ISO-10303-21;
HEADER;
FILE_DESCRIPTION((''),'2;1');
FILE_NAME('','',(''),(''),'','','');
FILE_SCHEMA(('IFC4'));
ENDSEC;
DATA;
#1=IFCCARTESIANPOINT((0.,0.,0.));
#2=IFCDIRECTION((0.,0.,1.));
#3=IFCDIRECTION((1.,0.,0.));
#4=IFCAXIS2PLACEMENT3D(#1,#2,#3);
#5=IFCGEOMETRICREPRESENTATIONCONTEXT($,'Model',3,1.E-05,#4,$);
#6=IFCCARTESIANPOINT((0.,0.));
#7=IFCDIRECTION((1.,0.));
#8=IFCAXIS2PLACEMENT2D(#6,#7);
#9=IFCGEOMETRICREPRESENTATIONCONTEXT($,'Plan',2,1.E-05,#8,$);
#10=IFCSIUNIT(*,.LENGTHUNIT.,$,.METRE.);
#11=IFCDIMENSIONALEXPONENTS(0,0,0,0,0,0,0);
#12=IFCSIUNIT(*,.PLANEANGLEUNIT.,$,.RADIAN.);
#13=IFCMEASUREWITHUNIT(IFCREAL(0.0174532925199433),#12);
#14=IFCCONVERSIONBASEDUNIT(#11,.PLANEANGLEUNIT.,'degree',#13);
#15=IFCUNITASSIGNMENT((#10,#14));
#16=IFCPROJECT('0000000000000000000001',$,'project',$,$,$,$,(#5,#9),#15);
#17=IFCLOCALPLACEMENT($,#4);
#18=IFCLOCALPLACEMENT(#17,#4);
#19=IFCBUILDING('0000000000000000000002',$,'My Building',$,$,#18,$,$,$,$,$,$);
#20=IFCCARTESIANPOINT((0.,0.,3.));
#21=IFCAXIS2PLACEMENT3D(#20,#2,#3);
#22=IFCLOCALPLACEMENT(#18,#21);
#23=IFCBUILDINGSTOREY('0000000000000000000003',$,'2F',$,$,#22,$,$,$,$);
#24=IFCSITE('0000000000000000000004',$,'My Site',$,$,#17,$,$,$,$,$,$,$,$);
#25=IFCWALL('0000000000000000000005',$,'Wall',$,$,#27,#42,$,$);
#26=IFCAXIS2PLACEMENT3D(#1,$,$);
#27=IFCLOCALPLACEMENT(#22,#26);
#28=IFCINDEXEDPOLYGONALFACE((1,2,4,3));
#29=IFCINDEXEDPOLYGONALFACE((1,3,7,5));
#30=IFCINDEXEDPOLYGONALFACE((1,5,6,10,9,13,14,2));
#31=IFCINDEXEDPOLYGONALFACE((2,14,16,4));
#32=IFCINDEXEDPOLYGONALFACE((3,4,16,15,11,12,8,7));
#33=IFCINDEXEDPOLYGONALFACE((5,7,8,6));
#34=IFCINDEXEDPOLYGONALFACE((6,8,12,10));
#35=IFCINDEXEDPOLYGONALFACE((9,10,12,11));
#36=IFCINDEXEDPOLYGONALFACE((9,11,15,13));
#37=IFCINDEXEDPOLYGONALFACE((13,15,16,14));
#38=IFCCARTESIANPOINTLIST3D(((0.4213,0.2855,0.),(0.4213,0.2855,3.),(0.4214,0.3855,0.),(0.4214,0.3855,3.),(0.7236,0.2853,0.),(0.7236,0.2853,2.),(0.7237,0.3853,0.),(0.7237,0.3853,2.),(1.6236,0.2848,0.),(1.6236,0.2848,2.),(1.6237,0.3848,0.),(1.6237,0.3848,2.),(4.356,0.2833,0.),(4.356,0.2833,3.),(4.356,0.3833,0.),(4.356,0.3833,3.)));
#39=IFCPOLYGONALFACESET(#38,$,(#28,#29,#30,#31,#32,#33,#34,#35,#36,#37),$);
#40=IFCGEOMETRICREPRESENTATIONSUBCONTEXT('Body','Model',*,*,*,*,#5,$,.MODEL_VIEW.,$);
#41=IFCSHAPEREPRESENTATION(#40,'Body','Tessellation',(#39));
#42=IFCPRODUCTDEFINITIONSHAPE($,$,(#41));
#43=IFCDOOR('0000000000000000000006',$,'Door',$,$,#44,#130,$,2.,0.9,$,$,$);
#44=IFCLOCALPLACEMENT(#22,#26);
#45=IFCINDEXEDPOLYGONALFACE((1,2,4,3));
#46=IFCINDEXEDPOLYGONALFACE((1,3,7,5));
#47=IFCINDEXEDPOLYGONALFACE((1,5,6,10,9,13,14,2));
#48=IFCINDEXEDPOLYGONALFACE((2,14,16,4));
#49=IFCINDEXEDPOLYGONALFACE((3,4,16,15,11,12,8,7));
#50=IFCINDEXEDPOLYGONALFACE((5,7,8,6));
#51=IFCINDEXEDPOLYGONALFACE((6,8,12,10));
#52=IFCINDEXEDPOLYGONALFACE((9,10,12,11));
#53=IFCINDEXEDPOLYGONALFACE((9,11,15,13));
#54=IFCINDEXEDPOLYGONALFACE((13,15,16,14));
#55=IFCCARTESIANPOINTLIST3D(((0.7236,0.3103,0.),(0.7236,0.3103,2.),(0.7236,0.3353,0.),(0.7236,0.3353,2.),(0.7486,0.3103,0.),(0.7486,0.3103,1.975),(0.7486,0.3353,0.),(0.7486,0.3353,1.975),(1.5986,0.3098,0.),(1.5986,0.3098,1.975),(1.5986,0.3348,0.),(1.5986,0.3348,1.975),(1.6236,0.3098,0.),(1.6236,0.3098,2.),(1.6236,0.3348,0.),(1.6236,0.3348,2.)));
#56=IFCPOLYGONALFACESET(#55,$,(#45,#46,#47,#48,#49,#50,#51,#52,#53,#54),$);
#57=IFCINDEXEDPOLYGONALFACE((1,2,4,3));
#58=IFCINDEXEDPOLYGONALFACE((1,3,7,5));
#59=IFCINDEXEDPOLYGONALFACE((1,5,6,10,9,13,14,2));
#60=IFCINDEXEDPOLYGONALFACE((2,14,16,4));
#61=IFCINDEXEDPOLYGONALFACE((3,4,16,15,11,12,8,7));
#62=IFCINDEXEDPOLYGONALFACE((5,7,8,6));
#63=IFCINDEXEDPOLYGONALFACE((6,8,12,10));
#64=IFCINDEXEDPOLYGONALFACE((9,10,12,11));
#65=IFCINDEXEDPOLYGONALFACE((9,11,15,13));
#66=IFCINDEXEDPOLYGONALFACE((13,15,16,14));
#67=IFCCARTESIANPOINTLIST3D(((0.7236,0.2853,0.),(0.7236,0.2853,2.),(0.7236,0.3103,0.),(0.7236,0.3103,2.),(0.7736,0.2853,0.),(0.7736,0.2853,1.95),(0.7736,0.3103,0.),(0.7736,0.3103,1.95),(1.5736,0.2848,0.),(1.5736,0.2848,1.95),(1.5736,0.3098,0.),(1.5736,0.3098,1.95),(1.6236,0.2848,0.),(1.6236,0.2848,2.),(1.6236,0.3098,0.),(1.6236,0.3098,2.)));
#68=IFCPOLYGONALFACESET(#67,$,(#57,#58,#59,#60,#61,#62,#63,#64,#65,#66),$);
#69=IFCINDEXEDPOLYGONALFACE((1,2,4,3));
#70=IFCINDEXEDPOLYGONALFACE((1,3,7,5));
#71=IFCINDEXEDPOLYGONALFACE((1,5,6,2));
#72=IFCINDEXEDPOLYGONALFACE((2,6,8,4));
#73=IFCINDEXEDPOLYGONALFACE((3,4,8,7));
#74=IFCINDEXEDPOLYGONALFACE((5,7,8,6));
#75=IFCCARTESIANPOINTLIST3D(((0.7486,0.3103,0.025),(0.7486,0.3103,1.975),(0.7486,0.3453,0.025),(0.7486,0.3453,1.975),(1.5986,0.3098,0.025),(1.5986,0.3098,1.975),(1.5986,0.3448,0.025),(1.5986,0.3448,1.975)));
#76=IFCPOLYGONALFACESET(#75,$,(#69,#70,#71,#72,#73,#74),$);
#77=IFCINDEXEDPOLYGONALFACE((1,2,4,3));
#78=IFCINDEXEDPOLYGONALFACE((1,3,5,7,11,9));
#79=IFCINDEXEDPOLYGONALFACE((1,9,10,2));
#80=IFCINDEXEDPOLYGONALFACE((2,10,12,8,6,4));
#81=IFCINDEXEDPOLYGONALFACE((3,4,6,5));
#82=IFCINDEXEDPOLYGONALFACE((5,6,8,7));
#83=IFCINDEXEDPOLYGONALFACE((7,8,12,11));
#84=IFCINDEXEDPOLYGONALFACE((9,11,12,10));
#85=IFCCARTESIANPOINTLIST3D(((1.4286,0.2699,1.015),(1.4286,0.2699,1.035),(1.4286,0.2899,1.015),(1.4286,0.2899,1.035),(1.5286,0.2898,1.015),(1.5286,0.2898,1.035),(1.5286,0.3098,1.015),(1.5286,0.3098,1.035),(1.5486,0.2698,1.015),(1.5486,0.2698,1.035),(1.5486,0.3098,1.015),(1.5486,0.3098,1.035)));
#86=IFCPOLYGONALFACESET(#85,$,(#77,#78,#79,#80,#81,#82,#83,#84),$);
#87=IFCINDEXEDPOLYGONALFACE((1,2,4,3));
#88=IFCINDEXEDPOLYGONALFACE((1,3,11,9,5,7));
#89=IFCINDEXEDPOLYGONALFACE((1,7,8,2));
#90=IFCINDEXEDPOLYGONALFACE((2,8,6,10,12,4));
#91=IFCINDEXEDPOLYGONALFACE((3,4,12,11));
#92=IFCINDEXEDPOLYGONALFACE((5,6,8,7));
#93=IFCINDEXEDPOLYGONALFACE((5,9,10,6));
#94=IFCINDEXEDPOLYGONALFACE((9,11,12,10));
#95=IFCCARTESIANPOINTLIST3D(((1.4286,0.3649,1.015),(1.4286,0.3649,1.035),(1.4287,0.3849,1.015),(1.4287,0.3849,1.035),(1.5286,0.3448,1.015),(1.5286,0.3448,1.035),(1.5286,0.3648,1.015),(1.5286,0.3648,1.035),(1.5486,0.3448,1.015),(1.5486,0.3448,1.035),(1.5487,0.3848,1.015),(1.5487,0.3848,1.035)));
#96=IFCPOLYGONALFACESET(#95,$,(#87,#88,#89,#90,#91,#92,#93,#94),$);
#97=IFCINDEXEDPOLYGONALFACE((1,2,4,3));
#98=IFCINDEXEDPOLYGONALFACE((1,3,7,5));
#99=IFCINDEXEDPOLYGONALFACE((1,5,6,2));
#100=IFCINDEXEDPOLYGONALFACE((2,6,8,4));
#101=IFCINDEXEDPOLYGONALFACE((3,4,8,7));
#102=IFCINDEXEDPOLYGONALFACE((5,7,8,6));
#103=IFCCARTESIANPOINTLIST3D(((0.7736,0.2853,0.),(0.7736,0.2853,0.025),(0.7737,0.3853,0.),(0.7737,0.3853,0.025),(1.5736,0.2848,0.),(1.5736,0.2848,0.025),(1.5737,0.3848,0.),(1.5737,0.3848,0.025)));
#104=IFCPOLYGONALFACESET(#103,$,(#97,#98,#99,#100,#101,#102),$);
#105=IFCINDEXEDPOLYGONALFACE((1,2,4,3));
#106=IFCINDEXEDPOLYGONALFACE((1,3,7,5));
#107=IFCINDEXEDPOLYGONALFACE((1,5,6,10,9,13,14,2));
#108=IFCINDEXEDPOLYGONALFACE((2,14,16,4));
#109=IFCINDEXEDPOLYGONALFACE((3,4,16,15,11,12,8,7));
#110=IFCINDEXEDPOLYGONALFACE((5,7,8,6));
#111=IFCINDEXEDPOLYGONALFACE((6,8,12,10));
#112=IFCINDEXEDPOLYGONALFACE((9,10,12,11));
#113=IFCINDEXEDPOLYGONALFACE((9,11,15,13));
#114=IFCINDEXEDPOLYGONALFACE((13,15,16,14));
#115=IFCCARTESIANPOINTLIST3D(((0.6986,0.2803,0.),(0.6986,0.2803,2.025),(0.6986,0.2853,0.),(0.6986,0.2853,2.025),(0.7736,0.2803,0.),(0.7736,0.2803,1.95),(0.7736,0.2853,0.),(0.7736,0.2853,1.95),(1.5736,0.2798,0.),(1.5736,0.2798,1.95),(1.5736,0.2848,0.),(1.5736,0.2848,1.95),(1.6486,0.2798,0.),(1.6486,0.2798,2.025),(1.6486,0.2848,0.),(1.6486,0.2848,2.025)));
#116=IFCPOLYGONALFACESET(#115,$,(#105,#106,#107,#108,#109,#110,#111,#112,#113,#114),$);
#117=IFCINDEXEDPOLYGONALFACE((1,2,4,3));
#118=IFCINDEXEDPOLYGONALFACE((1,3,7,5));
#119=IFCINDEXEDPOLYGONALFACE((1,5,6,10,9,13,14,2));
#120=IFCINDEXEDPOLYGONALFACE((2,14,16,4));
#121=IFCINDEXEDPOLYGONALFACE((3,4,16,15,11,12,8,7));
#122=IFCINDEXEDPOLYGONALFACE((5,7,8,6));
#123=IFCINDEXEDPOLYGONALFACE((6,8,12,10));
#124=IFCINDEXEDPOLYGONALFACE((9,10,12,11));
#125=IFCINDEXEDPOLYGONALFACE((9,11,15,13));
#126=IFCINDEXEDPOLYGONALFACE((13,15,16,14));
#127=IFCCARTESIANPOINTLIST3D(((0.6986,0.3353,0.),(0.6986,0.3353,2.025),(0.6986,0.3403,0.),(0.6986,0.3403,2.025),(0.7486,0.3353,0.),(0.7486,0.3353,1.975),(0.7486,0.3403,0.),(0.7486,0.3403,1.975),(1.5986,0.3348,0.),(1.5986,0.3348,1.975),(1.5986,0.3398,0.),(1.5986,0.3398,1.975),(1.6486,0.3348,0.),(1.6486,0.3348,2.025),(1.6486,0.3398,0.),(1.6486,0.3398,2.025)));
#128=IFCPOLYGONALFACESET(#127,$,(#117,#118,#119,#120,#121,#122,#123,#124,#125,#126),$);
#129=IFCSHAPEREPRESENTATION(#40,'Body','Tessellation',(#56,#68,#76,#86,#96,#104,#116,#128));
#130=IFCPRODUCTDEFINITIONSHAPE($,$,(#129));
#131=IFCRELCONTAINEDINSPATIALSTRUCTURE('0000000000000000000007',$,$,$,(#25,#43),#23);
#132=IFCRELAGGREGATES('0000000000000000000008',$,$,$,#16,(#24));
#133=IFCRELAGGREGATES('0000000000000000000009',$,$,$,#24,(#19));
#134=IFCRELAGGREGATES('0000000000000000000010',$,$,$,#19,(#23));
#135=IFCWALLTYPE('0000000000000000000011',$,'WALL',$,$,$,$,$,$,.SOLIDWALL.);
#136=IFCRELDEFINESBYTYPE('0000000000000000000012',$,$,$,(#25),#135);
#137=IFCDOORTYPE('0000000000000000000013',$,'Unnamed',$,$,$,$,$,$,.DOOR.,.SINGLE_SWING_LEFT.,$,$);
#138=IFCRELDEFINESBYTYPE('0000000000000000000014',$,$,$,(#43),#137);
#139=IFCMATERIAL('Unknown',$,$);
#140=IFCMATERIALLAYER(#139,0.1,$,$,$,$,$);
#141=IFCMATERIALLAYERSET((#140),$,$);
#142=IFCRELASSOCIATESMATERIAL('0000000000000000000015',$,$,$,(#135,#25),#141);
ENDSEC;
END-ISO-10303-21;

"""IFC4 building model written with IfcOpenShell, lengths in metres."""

from ifc_helpers import new_model, entity, si_unit, converted_unit, frame, origin_with_axes, origin_2d_with_axis, place, context, subcontext, project, spatial, line, indexed_curve, outline, extrude, shape, source, transform, mapped, material, layer, layer_set, layer_usage, type_object, type_shapes, element, fill, save


model = new_model("IFC4")

# Units and contexts
model_context = context("Model", 3, precision=1e-05, world=origin_with_axes())
plan_context = context("Plan", 2, precision=1e-05, world=origin_2d_with_axis())
body_context_1 = subcontext(model_context, "Body", "Model", "MODEL_VIEW")
body_context_2 = subcontext(plan_context, "Body", "Plan", "PLAN_VIEW")
ifc_project = project(units=[si_unit("LENGTHUNIT", "METRE"), converted_unit("PLANEANGLEUNIT", "degree", entity("IfcReal", 0.0174532925199433), si_unit("PLANEANGLEUNIT", "RADIAN"), dimensions=[0, 0, 0, 0, 0, 0, 0])], contexts=[model_context, plan_context])

# Site, building, storey
site_placement = place(None, origin_with_axes())
site = spatial("IfcSite", under=ifc_project, at=site_placement, Name="My Site")
building_placement = place(site_placement, origin_with_axes())
building = spatial("IfcBuilding", under=site, at=building_placement, Name="My Building")
storey_placement = place(building_placement, frame((0.0, 0.0, 3.0), z_axis=(0.0, 0.0, 1.0), x_axis=(1.0, 0.0, 0.0)))
storey = spatial("IfcBuildingStorey", under=building, at=storey_placement, Name="2F")

# Shared definitions
ifc_material = material(Name="Unknown")

# Shared definitions
ifc_layer_1 = layer(ifc_material, 0.1)
ifc_layer_set_1 = layer_set([ifc_layer_1])
wall_type = type_object("IfcWallType", Name="WALL", PredefinedType="SOLIDWALL", material=ifc_layer_set_1)

# Shared definitions
shared_shape_1 = source(origin_with_axes(), body_context_1, "Body", "SweptSolid", [
    extrude(outline(indexed_curve([(0.0, 0.0), (0.9, 0.0), (0.9, 2.0), (0.0, 2.0)], segments=[line(1, 2, 3, 4, 1)])), frame((0.0, -0.6, 0.0), z_axis=(0.0, -1.0, 0.0), x_axis=(1.0, 0.0, 0.0)), (0.0, 0.0, -1.0), 1.2),
])
door_type = type_object("IfcDoorType", Name="Unnamed", OperationType="SINGLE_SWING_LEFT", PredefinedType="DOOR")
shared_shape_2 = source(origin_with_axes(), body_context_1, "Body", "SweptSolid", [
    extrude(outline(indexed_curve([(0.0, 0.0), (0.0, 2.0), (0.9, 2.0), (0.9, 0.0), (0.875, 0.0), (0.875, 1.975), (0.025, 1.975), (0.025, 0.0)], segments=[line(1, 2, 3, 4, 5, 6, 7, 8, 1)])), frame((0.0, 0.025, 0.0), z_axis=(0.0, -1.0, 0.0), x_axis=(1.0, 0.0, 0.0)), (0.0, 0.0, -1.0), 0.025),
    extrude(outline(indexed_curve([(0.0, 0.0), (0.0, 2.0), (0.9, 2.0), (0.9, 0.0), (0.85, 0.0), (0.85, 1.95), (0.05, 1.95), (0.05, 0.0)], segments=[line(1, 2, 3, 4, 5, 6, 7, 8, 1)])), frame((0.0, 0.0, 0.0), z_axis=(0.0, -1.0, 0.0), x_axis=(1.0, 0.0, 0.0)), (0.0, 0.0, -1.0), 0.025),
    extrude(outline(indexed_curve([(0.0, 0.0), (0.85, 0.0), (0.85, 0.035), (0.0, 0.035)], segments=[line(1, 2, 3, 4, 1)])), frame((0.025, 0.025, 0.025), z_axis=(0.0, 0.0, 1.0), x_axis=(1.0, 0.0, 0.0)), (0.0, 0.0, 1.0), 1.95),
    extrude(outline(indexed_curve([(0.0, 0.0), (0.0, -0.04), (-0.12, -0.04), (-0.12, -0.02), (-0.02, -0.02), (-0.02, 0.0)], segments=[line(1, 2, 3, 4, 5, 6, 1)])), frame((0.825, 0.025, 1.015), z_axis=(0.0, 0.0, 1.0), x_axis=(1.0, 0.0, 0.0)), (0.0, 0.0, 1.0), 0.02),
    extrude(outline(indexed_curve([(0.0, 0.0), (0.0, 0.04), (-0.12, 0.04), (-0.12, 0.02), (-0.02, 0.02), (-0.02, 0.0)], segments=[line(1, 2, 3, 4, 5, 6, 1)])), frame((0.825, 0.06, 1.015), z_axis=(0.0, 0.0, 1.0), x_axis=(1.0, 0.0, 0.0)), (0.0, 0.0, 1.0), 0.02),
    extrude(outline(indexed_curve([(0.0, 0.0), (0.8, 0.0), (0.8, 0.1), (0.0, 0.1)], segments=[line(1, 2, 3, 4, 1)])), frame((0.05, 0.0, 0.0), z_axis=(0.0, 0.0, 1.0), x_axis=(1.0, 0.0, 0.0)), (0.0, 0.0, 1.0), 0.025),
    extrude(outline(indexed_curve([(0.0, 0.0), (0.0, 2.025), (0.95, 2.025), (0.95, 0.0), (0.875, 0.0), (0.875, 1.95), (0.075, 1.95), (0.075, 0.0)], segments=[line(1, 2, 3, 4, 5, 6, 7, 8, 1)])), frame((-0.025, -0.005, 0.0), z_axis=(0.0, -1.0, 0.0), x_axis=(1.0, 0.0, 0.0)), (0.0, 0.0, -1.0), 0.005),
    extrude(outline(indexed_curve([(0.0, 0.0), (0.0, 2.025), (0.95, 2.025), (0.95, 0.0), (0.9, 0.0), (0.9, 1.975), (0.05, 1.975), (0.05, 0.0)], segments=[line(1, 2, 3, 4, 5, 6, 7, 8, 1)])), frame((-0.025, 0.05, 0.0), z_axis=(0.0, -1.0, 0.0), x_axis=(1.0, 0.0, 0.0)), (0.0, 0.0, -1.0), 0.005),
])
shared_shape_3 = source(origin_with_axes(), body_context_2, "Body", "Curve2D", [
    entity("IfcIndexedPolyCurve", entity("IfcCartesianPointList2D", [[0.0, 0.0], [0.0, 0.05], [0.025, 0.05], [0.025, 0.025], [0.05, 0.025], [0.05, 0.0]]), [entity("IfcLineIndex", [1, 2, 3, 4, 5, 6, 1])]),
    entity("IfcIndexedPolyCurve", entity("IfcCartesianPointList2D", [[0.9, 0.0], [0.9, 0.05], [0.875, 0.05], [0.875, 0.025], [0.85, 0.025], [0.85, 0.0]]), [entity("IfcLineIndex", [1, 2, 3, 4, 5, 6, 1])]),
    entity("IfcTrimmedCurve", entity("IfcEllipse", entity("IfcAxis2Placement2D", entity("IfcCartesianPoint", [0.06, 0.05]), entity("IfcDirection", [1.0, 0.0])), 0.815, 0.85), [entity("IfcCartesianPoint", [0.875, 0.05])], [entity("IfcCartesianPoint", [0.06, 0.9])], True, "CARTESIAN"),
    entity("IfcIndexedPolyCurve", entity("IfcCartesianPointList2D", [[0.025, 0.05], [0.06, 0.05], [0.06, 0.9], [0.025, 0.9]]), [entity("IfcLineIndex", [1, 2, 3, 4, 1])]),
])
type_shapes(door_type, [shared_shape_2, shared_shape_3])

# Wall, opening, door
ifc_layer_usage_1 = layer_usage(ifc_layer_set_1, "AXIS2", "POSITIVE", 0.0)
wall_1_placement = place(storey_placement, frame((0.4213, 0.2855, 0.0), z_axis=(0.0, 0.0, 1.0), x_axis=(1.0, -0.000561, 0.0)))
wall_1 = element("IfcWall", 1, at=wall_1_placement, inside=storey, type_object=wall_type, material=ifc_layer_usage_1, Name="Wall", context=body_context_1, shape_type="SweptSolid", body=[
    extrude(outline(indexed_curve([(0.0, 0.0), (0.0, 0.1), (3.9347, 0.1), (3.9347, 0.0)], segments=[line(1, 2, 3, 4, 1)])), origin_with_axes(), (0.0, 0.0, 1.0), 3.0),
])
opening_1_placement = place(wall_1_placement, frame((0.3023, 0.0, 0.0), z_axis=(0.0, 0.0, 1.0), x_axis=(1.0, 0.0, 0.0)))
opening_1 = element("IfcOpeningElement", 2, at=opening_1_placement, cuts=wall_1, PredefinedType="OPENING", context=body_context_1, shape_type="MappedRepresentation", body=[
    mapped(shared_shape_1, transform((0.0, 0.0, 0.0), x_axis=(1.0, 0.0, 0.0), y_axis=(0.0, 1.0, 0.0), z_axis=(0.0, 0.0, 1.0), scale=1.0)),
])
door_1_placement = place(opening_1_placement, frame((0.0, 0.0, 0.0), z_axis=(0.0, 0.0, 1.0), x_axis=(1.0, 0.0, 0.0)))
door_1 = element("IfcDoor", 3, at=door_1_placement, inside=storey, type_object=door_type, Name="Door", OverallHeight=2.0, OverallWidth=0.9, shapes=[
    shape(body_context_1, "Body", "MappedRepresentation", [mapped(shared_shape_2, transform((0.0, 0.0, 0.0), x_axis=(1.0, 0.0, 0.0), y_axis=(0.0, 1.0, 0.0), z_axis=(0.0, 0.0, 1.0), scale=1.0))]),
    shape(body_context_2, "Body", "MappedRepresentation", [mapped(shared_shape_3, transform((0.0, 0.0, 0.0), x_axis=(1.0, 0.0, 0.0), y_axis=(0.0, 1.0, 0.0), z_axis=(0.0, 0.0, 1.0), scale=1.0))]),
])
fill(opening_1, door_1)

save(model, "model.ifc")
